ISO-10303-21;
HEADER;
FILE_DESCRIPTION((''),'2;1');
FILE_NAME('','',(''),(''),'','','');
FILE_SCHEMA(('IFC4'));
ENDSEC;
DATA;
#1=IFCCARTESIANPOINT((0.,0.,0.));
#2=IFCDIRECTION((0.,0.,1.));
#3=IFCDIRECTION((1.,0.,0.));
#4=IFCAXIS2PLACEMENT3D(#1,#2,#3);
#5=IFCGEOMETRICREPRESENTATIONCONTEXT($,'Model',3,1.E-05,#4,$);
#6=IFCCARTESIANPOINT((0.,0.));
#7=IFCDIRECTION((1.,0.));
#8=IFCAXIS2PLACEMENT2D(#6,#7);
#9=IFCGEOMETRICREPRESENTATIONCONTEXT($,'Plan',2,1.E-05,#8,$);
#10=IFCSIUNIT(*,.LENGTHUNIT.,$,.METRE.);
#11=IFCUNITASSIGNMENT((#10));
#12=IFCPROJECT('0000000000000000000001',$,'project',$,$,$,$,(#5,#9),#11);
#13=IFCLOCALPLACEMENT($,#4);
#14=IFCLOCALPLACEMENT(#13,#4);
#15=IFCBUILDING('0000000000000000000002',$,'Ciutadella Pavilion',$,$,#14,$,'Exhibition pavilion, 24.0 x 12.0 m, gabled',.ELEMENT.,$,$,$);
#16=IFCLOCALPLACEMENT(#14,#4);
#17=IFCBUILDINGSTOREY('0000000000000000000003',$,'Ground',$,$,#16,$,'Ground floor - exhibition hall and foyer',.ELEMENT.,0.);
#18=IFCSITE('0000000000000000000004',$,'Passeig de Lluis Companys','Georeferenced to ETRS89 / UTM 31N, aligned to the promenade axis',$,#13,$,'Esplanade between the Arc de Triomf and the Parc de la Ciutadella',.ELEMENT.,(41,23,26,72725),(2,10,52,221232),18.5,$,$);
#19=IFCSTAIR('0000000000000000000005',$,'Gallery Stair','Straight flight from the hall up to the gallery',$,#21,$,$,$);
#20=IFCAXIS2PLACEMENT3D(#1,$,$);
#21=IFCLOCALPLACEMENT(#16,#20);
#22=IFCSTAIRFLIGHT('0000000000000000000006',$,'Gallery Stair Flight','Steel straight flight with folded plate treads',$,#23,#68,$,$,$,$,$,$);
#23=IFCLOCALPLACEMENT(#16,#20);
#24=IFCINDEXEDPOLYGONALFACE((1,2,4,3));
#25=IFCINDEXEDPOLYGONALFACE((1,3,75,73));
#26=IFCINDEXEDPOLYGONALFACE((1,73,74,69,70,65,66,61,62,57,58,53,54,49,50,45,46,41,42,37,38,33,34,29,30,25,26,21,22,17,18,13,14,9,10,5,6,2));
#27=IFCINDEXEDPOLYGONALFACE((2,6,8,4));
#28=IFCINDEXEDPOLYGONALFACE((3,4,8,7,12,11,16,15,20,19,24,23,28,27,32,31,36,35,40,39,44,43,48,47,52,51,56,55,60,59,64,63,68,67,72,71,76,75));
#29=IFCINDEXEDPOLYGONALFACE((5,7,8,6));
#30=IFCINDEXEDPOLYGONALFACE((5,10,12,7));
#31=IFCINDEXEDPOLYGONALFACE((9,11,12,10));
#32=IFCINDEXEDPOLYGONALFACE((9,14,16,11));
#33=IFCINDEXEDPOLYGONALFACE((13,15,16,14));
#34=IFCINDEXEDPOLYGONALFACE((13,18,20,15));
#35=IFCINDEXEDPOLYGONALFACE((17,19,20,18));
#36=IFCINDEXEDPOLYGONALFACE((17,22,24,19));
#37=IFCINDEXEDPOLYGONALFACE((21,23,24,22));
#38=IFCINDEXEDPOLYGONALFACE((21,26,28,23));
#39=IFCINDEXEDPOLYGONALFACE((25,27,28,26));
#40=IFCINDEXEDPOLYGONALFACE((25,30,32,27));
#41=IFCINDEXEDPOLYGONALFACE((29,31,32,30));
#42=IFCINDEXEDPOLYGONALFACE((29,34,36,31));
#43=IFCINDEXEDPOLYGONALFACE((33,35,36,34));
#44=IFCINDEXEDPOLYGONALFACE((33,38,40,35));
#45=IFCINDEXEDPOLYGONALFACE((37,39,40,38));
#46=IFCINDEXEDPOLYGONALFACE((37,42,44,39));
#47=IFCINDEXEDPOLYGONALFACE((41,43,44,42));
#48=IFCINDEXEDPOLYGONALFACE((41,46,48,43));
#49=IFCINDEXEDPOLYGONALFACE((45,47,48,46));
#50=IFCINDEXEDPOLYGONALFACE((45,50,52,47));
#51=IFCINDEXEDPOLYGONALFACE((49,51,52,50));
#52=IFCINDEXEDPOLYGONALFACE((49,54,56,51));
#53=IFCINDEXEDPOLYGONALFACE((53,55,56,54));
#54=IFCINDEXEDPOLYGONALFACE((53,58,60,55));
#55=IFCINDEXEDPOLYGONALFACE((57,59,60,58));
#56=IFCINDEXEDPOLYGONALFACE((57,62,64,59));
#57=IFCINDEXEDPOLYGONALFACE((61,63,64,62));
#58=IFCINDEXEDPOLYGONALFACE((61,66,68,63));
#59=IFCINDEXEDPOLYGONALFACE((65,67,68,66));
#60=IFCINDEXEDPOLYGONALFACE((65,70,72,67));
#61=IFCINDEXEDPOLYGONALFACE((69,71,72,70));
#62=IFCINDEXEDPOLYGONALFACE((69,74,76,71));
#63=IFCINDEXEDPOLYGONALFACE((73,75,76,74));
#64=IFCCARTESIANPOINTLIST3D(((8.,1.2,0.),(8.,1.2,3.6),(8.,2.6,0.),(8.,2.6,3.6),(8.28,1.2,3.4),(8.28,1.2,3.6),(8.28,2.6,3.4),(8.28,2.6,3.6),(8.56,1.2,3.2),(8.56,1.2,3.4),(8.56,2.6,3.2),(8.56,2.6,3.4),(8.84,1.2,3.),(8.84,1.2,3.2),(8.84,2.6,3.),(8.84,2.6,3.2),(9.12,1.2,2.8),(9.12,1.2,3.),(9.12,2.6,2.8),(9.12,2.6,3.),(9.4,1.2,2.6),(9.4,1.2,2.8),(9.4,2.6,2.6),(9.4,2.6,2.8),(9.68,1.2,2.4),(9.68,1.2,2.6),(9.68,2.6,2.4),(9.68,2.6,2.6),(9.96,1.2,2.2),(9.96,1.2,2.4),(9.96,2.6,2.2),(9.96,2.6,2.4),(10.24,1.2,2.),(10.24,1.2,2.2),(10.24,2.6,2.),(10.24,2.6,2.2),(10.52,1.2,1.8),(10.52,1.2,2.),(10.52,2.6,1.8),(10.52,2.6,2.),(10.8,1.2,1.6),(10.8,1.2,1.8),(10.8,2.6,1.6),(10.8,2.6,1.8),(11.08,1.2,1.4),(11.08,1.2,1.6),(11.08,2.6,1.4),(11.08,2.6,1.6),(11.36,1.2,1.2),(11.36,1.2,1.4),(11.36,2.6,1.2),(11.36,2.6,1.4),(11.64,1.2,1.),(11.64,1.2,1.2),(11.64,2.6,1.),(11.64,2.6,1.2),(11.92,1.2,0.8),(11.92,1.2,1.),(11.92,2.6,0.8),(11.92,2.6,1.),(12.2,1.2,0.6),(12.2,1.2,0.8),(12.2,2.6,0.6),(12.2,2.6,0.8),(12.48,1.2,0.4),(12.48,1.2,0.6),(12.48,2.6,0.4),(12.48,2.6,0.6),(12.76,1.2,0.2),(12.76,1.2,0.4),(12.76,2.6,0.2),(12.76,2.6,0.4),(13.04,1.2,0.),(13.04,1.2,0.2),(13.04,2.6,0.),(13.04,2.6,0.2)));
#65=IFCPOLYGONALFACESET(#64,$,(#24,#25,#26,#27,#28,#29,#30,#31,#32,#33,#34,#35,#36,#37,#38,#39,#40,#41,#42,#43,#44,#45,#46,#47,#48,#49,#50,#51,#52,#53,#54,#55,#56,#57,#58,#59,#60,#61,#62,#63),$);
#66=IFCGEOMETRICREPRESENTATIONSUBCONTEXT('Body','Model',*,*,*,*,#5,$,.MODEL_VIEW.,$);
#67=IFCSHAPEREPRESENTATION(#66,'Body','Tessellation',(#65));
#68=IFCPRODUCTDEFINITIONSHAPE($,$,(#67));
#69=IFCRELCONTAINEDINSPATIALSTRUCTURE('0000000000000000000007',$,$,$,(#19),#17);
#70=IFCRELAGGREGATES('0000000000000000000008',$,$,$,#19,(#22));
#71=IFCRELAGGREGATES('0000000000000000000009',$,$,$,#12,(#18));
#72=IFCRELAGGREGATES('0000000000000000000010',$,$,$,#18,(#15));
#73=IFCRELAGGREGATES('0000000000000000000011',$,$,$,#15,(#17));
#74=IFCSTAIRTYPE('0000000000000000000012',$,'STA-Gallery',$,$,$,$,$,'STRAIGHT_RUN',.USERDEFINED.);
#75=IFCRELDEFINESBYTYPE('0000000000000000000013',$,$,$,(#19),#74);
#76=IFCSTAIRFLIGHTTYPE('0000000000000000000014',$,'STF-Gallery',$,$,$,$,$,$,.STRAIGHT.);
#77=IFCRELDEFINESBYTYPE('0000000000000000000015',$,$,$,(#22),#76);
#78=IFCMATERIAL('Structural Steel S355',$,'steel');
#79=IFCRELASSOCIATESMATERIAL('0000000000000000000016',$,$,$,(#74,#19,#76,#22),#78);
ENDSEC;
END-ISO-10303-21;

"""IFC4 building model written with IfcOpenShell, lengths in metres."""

from ifc_helpers import new_model, si_unit, frame, origin_with_axes, origin_2d_with_axis, place, context, subcontext, project, spatial, line, indexed_curve, outline, extrude, material, type_object, element, aggregate, save


model = new_model("IFC4")

# Units and contexts
model_context = context("Model", 3, precision=1e-05, world=origin_with_axes())
plan_context = context("Plan", 2, precision=1e-05, world=origin_2d_with_axis())
body_context = subcontext(model_context, "Body", "Model", "MODEL_VIEW")
ifc_project = project(units=[si_unit("LENGTHUNIT", "METRE")], contexts=[model_context, plan_context])

# Site, building, storey
site_placement = place(None, origin_with_axes())
site = spatial("IfcSite", under=ifc_project, at=site_placement, Name="Passeig de Lluis Companys", Description="Georeferenced to ETRS89 / UTM 31N, aligned to the promenade axis", LongName="Esplanade between the Arc de Triomf and the Parc de la Ciutadella", CompositionType="ELEMENT", RefLatitude=(41, 23, 26, 72725), RefLongitude=(2, 10, 52, 221232), RefElevation=18.5)
building_placement = place(site_placement, origin_with_axes())
building = spatial("IfcBuilding", under=site, at=building_placement, Name="Ciutadella Pavilion", LongName="Exhibition pavilion, 24.0 x 12.0 m, gabled", CompositionType="ELEMENT")
storey_placement = place(building_placement, origin_with_axes())
storey = spatial("IfcBuildingStorey", under=building, at=storey_placement, Name="Ground", LongName="Ground floor - exhibition hall and foyer", CompositionType="ELEMENT", Elevation=0.0)

# Shared definitions
ifc_material_1 = material(Name="Structural Steel S355", Category="steel")

# Stair, stair flight
stair_type = type_object("IfcStairType", Name="STA-Gallery", ElementType="STRAIGHT_RUN", PredefinedType="USERDEFINED", material=ifc_material_1)
stair_placement = place(storey_placement, frame((13.04, 1.2, 0.0), z_axis=(0.0, 0.0, 1.0), x_axis=(1.0, 0.0, 0.0)))
stair = element("IfcStair", 1, at=stair_placement, inside=storey, type_object=stair_type, material=ifc_material_1, Name="Gallery Stair", Description="Straight flight from the hall up to the gallery")
stair_flight_type = type_object("IfcStairFlightType", Name="STF-Gallery", PredefinedType="STRAIGHT", material=ifc_material_1)
stair_flight_placement = place(stair_placement, frame((0.0, 0.0, 0.0), z_axis=(0.0, 1.0, 0.0), x_axis=(-1.0, 0.0, 0.0)))
stair_flight = element("IfcStairFlight", 2, at=stair_flight_placement, type_object=stair_flight_type, material=ifc_material_1, Name="Gallery Stair Flight", Description="Steel straight flight with folded plate treads", context=body_context, shape_type="SweptSolid", body=[
    extrude(outline(indexed_curve([(0.0, 0.0), (5.04, 0.0), (5.04, 3.6), (4.76, 3.6), (4.76, 3.4), (4.48, 3.4), (4.48, 3.2), (4.2, 3.2), (4.2, 3.0), (3.92, 3.0), (3.92, 2.8), (3.64, 2.8), (3.64, 2.6), (3.36, 2.6), (3.36, 2.4), (3.08, 2.4), (3.08, 2.2), (2.8, 2.2), (2.8, 2.0), (2.52, 2.0), (2.52, 1.8), (2.24, 1.8), (2.24, 1.6), (1.96, 1.6), (1.96, 1.4), (1.68, 1.4), (1.68, 1.2), (1.4, 1.2), (1.4, 1.0), (1.12, 1.0), (1.12, 0.8), (0.84, 0.8), (0.84, 0.6), (0.56, 0.6), (0.56, 0.4), (0.28, 0.4), (0.28, 0.2), (0.0, 0.2)], segments=[line(1, 2, 3, 4, 5, 6, 7, 8, 9, 10, 11, 12, 13, 14, 15, 16, 17, 18, 19, 20, 21, 22, 23, 24, 25, 26, 27, 28, 29, 30, 31, 32, 33, 34, 35, 36, 37, 38, 1)])), origin_with_axes(), (0.0, 0.0, 1.0), 1.4),
])
aggregate(stair, [stair_flight])

save(model, "model.ifc")
